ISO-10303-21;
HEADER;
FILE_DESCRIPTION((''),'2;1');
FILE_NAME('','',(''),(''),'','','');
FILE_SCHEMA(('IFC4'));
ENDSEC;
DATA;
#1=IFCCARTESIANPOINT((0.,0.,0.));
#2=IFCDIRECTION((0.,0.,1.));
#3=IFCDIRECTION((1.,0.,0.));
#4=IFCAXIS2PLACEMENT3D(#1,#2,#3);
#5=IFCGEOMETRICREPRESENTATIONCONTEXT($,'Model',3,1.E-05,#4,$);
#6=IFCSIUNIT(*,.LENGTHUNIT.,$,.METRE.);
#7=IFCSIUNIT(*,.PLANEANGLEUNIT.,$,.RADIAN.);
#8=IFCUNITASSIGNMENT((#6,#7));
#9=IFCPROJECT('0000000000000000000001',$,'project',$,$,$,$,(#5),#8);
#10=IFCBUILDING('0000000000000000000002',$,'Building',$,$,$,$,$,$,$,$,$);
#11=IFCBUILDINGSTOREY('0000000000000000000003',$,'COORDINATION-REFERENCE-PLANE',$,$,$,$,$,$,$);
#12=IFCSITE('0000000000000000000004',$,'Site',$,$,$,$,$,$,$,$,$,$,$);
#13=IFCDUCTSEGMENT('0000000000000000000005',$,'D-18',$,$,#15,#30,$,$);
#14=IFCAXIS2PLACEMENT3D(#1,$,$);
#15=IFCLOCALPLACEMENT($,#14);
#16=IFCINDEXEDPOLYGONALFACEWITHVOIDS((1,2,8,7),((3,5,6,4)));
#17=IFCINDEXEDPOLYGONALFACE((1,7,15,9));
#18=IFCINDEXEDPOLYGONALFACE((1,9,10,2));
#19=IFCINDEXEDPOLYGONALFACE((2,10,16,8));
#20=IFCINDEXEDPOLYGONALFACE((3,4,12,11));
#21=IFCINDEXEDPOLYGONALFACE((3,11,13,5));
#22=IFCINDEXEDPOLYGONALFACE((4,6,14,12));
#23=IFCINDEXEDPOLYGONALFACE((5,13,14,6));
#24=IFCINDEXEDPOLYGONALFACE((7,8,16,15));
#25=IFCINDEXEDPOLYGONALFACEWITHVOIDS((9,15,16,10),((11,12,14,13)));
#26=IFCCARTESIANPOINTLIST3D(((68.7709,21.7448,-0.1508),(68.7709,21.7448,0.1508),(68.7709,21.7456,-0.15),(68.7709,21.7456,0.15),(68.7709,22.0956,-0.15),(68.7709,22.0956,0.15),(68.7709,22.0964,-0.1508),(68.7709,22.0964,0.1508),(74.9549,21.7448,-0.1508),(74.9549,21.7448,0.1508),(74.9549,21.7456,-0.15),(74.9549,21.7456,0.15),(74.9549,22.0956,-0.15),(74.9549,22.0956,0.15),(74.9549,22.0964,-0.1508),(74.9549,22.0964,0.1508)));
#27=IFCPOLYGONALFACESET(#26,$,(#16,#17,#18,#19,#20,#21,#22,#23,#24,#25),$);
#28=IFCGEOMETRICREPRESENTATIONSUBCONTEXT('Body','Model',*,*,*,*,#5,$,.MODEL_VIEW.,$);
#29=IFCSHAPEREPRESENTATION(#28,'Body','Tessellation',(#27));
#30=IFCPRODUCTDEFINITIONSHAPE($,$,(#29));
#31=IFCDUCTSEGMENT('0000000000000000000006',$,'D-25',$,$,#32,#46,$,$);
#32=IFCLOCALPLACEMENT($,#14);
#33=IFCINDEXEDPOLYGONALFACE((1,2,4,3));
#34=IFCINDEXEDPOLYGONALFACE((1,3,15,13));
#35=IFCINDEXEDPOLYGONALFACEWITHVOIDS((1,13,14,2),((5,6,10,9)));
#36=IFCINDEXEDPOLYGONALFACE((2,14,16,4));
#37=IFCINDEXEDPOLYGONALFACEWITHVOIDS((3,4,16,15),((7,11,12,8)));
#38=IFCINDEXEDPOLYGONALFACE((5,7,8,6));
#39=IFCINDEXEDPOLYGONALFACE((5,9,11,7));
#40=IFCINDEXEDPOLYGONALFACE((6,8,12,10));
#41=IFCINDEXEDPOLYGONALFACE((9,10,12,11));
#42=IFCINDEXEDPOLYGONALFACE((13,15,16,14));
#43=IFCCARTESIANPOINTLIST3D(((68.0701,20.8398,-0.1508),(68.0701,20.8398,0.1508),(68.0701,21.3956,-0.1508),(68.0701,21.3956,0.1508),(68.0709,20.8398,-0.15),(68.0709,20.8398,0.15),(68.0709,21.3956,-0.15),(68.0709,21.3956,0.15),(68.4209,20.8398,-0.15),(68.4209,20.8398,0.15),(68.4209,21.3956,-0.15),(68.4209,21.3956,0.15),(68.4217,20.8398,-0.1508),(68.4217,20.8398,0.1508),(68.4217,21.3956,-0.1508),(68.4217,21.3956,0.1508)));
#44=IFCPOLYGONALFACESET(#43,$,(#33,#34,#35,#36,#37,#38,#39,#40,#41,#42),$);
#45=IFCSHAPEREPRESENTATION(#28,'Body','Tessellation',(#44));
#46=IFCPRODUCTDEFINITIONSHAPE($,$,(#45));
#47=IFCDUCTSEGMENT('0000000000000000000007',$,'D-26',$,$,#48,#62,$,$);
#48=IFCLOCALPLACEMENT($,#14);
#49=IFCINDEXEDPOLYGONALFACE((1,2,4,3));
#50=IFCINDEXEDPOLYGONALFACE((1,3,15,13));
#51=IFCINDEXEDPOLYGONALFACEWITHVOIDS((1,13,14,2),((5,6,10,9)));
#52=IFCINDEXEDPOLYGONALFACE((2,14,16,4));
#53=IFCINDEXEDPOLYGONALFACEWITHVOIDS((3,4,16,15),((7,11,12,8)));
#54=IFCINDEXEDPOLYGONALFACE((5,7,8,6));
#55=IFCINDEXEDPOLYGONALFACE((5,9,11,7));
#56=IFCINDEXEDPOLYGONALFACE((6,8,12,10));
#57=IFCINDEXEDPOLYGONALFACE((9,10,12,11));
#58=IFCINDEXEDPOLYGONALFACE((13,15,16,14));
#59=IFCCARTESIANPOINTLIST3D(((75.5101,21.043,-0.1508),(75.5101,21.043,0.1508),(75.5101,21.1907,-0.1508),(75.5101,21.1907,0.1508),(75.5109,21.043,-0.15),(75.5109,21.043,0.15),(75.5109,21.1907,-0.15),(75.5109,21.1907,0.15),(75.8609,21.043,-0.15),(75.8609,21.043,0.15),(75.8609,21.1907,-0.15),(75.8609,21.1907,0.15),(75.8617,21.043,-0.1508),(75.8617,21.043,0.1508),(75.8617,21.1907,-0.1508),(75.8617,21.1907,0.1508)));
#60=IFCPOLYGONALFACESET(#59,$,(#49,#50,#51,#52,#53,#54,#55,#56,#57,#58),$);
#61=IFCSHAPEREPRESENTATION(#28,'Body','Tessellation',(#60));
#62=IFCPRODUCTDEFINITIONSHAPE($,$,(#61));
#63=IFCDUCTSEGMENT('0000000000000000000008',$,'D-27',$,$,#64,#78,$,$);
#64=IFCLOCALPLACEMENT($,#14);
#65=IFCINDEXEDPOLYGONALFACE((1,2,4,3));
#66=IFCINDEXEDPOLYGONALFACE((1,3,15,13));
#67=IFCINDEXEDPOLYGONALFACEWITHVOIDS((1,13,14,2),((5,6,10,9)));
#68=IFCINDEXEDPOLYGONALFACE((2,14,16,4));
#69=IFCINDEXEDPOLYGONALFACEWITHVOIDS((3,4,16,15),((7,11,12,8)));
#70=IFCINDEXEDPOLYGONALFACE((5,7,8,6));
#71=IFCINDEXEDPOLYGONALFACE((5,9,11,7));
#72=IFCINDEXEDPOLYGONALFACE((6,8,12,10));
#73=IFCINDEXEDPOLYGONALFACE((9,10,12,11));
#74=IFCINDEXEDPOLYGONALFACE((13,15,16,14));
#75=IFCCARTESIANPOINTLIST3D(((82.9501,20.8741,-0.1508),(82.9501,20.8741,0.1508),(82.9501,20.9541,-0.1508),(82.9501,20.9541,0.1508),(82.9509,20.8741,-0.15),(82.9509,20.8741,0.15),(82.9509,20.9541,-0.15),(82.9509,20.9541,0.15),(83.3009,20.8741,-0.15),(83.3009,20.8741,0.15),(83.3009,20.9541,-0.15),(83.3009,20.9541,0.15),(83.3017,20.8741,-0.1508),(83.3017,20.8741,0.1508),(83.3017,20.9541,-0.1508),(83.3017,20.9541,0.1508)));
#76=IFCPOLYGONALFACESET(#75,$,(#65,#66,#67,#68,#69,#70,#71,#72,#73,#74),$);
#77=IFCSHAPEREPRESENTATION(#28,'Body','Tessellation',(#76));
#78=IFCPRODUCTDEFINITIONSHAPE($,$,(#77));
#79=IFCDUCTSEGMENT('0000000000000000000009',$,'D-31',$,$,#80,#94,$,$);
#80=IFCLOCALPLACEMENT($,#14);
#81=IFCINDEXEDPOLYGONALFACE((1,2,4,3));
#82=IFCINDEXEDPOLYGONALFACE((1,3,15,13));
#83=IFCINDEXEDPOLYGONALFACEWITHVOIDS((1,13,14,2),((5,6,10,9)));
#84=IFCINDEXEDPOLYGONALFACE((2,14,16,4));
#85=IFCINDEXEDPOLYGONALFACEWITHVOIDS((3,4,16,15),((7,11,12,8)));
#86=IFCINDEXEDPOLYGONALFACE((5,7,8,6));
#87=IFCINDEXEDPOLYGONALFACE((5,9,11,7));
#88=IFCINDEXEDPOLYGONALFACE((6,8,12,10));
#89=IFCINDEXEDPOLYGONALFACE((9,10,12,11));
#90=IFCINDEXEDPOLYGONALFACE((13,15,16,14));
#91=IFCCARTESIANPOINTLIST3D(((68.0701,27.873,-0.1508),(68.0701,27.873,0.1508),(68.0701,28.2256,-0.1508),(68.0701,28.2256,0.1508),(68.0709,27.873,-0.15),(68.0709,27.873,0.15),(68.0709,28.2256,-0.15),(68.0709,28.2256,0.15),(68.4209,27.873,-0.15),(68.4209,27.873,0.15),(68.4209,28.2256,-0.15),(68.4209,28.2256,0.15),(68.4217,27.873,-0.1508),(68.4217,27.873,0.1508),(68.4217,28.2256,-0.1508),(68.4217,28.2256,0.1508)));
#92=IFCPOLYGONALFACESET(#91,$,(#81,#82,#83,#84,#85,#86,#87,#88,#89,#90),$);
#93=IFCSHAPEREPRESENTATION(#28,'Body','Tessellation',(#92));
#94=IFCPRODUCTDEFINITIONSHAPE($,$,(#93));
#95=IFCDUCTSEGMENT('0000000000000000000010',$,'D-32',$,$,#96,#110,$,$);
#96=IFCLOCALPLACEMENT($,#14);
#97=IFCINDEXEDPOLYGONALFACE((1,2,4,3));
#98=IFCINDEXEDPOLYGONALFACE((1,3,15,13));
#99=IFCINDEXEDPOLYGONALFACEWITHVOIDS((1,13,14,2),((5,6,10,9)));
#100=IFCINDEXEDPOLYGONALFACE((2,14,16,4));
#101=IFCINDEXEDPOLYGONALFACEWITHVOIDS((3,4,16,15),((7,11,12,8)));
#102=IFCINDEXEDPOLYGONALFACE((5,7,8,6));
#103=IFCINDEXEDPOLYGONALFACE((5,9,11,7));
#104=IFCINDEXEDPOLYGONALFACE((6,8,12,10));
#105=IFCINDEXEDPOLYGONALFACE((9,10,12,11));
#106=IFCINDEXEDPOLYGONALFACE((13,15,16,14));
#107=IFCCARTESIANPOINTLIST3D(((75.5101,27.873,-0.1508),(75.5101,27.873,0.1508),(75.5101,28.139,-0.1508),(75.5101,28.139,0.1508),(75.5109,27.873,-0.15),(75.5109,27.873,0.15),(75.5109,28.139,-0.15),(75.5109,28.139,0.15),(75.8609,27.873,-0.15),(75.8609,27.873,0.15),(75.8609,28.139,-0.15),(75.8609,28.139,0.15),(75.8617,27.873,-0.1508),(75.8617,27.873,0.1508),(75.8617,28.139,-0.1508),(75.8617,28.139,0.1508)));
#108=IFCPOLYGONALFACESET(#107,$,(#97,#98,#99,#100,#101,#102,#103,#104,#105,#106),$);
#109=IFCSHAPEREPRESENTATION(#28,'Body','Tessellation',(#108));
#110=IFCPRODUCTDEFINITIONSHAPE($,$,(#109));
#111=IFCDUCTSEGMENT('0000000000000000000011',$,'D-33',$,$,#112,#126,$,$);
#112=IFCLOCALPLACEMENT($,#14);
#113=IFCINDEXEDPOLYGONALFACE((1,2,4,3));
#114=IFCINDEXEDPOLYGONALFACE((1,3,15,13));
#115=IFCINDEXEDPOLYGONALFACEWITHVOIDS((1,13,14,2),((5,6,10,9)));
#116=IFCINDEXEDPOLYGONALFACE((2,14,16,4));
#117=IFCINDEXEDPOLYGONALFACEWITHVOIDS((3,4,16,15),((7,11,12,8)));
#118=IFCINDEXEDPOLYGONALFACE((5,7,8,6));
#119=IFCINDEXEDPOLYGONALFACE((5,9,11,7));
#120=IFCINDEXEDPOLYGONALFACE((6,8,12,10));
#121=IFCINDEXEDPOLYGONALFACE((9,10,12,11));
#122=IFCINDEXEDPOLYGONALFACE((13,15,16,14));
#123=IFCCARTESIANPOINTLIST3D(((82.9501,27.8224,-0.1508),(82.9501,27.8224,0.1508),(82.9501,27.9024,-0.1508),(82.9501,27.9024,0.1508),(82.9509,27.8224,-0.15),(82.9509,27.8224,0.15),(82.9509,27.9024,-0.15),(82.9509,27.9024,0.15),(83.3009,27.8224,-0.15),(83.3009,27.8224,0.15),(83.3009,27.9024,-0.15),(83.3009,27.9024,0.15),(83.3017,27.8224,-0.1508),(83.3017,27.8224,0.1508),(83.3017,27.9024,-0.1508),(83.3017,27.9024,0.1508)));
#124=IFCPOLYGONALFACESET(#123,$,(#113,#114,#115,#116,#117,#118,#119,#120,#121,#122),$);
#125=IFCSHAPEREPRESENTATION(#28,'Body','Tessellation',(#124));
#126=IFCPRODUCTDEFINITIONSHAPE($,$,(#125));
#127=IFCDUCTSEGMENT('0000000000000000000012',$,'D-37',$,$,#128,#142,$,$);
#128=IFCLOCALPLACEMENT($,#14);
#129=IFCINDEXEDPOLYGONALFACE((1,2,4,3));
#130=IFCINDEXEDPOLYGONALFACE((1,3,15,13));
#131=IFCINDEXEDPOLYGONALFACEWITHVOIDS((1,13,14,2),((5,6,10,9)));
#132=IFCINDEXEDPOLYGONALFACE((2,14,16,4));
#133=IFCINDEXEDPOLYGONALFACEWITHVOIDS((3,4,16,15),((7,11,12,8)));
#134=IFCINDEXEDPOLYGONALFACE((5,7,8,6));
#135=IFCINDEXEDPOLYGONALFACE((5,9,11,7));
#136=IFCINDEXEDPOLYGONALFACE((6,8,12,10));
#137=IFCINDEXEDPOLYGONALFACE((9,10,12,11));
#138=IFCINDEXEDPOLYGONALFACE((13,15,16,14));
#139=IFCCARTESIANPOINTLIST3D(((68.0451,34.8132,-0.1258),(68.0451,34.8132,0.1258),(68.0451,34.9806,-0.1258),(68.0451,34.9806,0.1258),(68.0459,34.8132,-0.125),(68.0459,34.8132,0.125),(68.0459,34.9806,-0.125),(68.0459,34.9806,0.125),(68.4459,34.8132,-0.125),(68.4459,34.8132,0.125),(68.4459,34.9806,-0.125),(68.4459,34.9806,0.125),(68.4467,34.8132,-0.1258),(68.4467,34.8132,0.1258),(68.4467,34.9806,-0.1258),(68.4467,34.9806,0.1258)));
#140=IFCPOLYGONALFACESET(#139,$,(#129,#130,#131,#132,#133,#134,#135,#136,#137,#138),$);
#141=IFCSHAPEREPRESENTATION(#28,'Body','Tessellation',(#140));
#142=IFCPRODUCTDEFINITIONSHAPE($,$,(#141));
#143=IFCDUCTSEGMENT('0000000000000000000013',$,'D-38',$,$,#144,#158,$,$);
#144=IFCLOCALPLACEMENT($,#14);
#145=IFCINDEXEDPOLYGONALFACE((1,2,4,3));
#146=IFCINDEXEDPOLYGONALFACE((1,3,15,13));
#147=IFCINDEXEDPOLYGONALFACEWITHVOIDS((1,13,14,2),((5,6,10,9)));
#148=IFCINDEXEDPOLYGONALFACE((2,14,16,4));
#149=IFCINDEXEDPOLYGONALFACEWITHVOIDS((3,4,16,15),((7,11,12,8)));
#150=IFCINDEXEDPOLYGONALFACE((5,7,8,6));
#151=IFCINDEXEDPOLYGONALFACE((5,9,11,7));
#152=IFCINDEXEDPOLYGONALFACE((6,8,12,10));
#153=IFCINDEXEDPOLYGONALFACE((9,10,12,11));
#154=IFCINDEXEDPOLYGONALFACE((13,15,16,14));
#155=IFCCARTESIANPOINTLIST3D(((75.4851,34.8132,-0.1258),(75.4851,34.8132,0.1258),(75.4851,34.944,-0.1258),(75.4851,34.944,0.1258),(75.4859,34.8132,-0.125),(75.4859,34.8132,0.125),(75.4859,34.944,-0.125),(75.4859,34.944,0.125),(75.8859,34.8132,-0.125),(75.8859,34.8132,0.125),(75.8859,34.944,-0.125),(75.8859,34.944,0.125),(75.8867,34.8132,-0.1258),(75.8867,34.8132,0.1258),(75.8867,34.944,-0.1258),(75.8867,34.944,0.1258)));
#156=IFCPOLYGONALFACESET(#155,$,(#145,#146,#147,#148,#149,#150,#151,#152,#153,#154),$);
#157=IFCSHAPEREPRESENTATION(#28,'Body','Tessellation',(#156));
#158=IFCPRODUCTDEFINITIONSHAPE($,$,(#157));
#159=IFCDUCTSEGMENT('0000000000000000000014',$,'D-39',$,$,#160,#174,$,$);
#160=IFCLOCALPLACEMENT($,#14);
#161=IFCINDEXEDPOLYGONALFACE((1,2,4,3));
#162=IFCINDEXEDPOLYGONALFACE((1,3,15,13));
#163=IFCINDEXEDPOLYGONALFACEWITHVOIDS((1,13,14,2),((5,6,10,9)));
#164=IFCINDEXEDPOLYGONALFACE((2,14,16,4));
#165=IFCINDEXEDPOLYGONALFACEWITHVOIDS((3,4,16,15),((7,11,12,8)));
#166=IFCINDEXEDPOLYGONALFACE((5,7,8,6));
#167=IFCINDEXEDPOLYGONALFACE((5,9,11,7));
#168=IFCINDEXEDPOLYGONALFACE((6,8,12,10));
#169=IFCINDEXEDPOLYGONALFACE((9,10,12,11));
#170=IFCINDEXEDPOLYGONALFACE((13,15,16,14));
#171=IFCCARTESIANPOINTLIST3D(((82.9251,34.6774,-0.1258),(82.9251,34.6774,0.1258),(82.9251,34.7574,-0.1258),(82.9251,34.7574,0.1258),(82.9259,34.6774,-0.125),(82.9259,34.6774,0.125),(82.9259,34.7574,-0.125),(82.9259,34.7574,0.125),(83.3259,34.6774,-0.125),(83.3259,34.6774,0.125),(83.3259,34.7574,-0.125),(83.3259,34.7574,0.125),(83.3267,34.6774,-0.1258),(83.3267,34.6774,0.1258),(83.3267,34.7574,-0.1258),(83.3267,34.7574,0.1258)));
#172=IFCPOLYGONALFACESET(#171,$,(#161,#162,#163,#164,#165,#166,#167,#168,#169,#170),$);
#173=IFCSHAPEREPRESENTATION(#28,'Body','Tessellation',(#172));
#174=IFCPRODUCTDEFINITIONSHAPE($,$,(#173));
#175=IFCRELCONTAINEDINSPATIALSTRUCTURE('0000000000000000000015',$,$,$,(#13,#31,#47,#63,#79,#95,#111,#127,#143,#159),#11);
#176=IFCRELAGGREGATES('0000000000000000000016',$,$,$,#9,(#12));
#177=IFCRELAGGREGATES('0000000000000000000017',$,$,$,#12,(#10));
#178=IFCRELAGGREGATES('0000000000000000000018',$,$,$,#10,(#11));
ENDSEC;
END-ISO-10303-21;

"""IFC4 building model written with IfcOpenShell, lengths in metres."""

from ifc_helpers import new_model, si_unit, frame, origin, origin_with_axes, place, context, subcontext, project, spatial, hollow_rectangle, extrude, element, save


model = new_model("IFC4")

# Units and contexts
model_context = context("Model", 3, precision=1e-05, world=origin_with_axes())
body_context = subcontext(model_context, "Body", "Model", "MODEL_VIEW")
ifc_project = project(units=[si_unit("LENGTHUNIT", "METRE"), si_unit("PLANEANGLEUNIT", "RADIAN")], contexts=[model_context])

# Site, building, storey
site = spatial("IfcSite", under=ifc_project, Name="Site")
building = spatial("IfcBuilding", under=site, Name="Building")
storey = spatial("IfcBuildingStorey", under=building, Name="COORDINATION-REFERENCE-PLANE")

# Duct segments
duct_segment_1_placement = place(None, frame((68.7709, 21.9206, 0.0), z_axis=(1.0, 0.0, 0.0), x_axis=(0.0, 1.0, 0.0)))
element("IfcDuctSegment", 1, at=duct_segment_1_placement, inside=storey, Name="D-18", context=body_context, shape_type="SweptSolid", body=[
    extrude(hollow_rectangle(XDim=0.3516, YDim=0.3016, WallThickness=0.0008), origin(), (0.0, 0.0, 1.0), 6.1839),
])
duct_segment_2_placement = place(None, frame((68.2459, 20.8398, 0.0), z_axis=(0.0, 1.0, 0.0), x_axis=(1.0, 0.0, 0.0)))
element("IfcDuctSegment", 2, at=duct_segment_2_placement, inside=storey, Name="D-25", context=body_context, shape_type="SweptSolid", body=[
    extrude(hollow_rectangle(XDim=0.3516, YDim=0.3016, WallThickness=0.0008), origin(), (0.0, 0.0, 1.0), 0.5558),
])
duct_segment_3_placement = place(None, frame((75.6859, 21.043, 0.0), z_axis=(0.0, 1.0, 0.0), x_axis=(1.0, 0.0, 0.0)))
element("IfcDuctSegment", 3, at=duct_segment_3_placement, inside=storey, Name="D-26", context=body_context, shape_type="SweptSolid", body=[
    extrude(hollow_rectangle(XDim=0.3516, YDim=0.3016, WallThickness=0.0008), origin(), (0.0, 0.0, 1.0), 0.1477),
])
duct_segment_4_placement = place(None, frame((83.1259, 20.8741, 0.0), z_axis=(0.0, 1.0, 0.0), x_axis=(1.0, 0.0, 0.0)))
element("IfcDuctSegment", 4, at=duct_segment_4_placement, inside=storey, Name="D-27", context=body_context, shape_type="SweptSolid", body=[
    extrude(hollow_rectangle(XDim=0.3516, YDim=0.3016, WallThickness=0.0008), origin(), (0.0, 0.0, 1.0), 0.08),
])
duct_segment_5_placement = place(None, frame((68.2459, 27.873, 0.0), z_axis=(0.0, 1.0, 0.0), x_axis=(1.0, 0.0, 0.0)))
element("IfcDuctSegment", 5, at=duct_segment_5_placement, inside=storey, Name="D-31", context=body_context, shape_type="SweptSolid", body=[
    extrude(hollow_rectangle(XDim=0.3516, YDim=0.3016, WallThickness=0.0008), origin(), (0.0, 0.0, 1.0), 0.3526),
])
duct_segment_6_placement = place(None, frame((75.6859, 27.873, 0.0), z_axis=(0.0, 1.0, 0.0), x_axis=(1.0, 0.0, 0.0)))
element("IfcDuctSegment", 6, at=duct_segment_6_placement, inside=storey, Name="D-32", context=body_context, shape_type="SweptSolid", body=[
    extrude(hollow_rectangle(XDim=0.3516, YDim=0.3016, WallThickness=0.0008), origin(), (0.0, 0.0, 1.0), 0.266),
])
duct_segment_7_placement = place(None, frame((83.1259, 27.8224, 0.0), z_axis=(0.0, 1.0, 0.0), x_axis=(1.0, 0.0, 0.0)))
element("IfcDuctSegment", 7, at=duct_segment_7_placement, inside=storey, Name="D-33", context=body_context, shape_type="SweptSolid", body=[
    extrude(hollow_rectangle(XDim=0.3516, YDim=0.3016, WallThickness=0.0008), origin(), (0.0, 0.0, 1.0), 0.08),
])
duct_segment_8_placement = place(None, frame((68.2459, 34.8132, 0.0), z_axis=(0.0, 1.0, 0.0), x_axis=(1.0, 0.0, 0.0)))
element("IfcDuctSegment", 8, at=duct_segment_8_placement, inside=storey, Name="D-37", context=body_context, shape_type="SweptSolid", body=[
    extrude(hollow_rectangle(XDim=0.4016, YDim=0.2516, WallThickness=0.0008), origin(), (0.0, 0.0, 1.0), 0.1673),
])
duct_segment_9_placement = place(None, frame((75.6859, 34.8132, 0.0), z_axis=(0.0, 1.0, 0.0), x_axis=(1.0, 0.0, 0.0)))
element("IfcDuctSegment", 9, at=duct_segment_9_placement, inside=storey, Name="D-38", context=body_context, shape_type="SweptSolid", body=[
    extrude(hollow_rectangle(XDim=0.4016, YDim=0.2516, WallThickness=0.0008), origin(), (0.0, 0.0, 1.0), 0.1307),
])
duct_segment_10_placement = place(None, frame((83.1259, 34.6774, 0.0), z_axis=(0.0, 1.0, 0.0), x_axis=(1.0, 0.0, 0.0)))
element("IfcDuctSegment", 10, at=duct_segment_10_placement, inside=storey, Name="D-39", context=body_context, shape_type="SweptSolid", body=[
    extrude(hollow_rectangle(XDim=0.4016, YDim=0.2516, WallThickness=0.0008), origin(), (0.0, 0.0, 1.0), 0.08),
])

save(model, "model.ifc")
